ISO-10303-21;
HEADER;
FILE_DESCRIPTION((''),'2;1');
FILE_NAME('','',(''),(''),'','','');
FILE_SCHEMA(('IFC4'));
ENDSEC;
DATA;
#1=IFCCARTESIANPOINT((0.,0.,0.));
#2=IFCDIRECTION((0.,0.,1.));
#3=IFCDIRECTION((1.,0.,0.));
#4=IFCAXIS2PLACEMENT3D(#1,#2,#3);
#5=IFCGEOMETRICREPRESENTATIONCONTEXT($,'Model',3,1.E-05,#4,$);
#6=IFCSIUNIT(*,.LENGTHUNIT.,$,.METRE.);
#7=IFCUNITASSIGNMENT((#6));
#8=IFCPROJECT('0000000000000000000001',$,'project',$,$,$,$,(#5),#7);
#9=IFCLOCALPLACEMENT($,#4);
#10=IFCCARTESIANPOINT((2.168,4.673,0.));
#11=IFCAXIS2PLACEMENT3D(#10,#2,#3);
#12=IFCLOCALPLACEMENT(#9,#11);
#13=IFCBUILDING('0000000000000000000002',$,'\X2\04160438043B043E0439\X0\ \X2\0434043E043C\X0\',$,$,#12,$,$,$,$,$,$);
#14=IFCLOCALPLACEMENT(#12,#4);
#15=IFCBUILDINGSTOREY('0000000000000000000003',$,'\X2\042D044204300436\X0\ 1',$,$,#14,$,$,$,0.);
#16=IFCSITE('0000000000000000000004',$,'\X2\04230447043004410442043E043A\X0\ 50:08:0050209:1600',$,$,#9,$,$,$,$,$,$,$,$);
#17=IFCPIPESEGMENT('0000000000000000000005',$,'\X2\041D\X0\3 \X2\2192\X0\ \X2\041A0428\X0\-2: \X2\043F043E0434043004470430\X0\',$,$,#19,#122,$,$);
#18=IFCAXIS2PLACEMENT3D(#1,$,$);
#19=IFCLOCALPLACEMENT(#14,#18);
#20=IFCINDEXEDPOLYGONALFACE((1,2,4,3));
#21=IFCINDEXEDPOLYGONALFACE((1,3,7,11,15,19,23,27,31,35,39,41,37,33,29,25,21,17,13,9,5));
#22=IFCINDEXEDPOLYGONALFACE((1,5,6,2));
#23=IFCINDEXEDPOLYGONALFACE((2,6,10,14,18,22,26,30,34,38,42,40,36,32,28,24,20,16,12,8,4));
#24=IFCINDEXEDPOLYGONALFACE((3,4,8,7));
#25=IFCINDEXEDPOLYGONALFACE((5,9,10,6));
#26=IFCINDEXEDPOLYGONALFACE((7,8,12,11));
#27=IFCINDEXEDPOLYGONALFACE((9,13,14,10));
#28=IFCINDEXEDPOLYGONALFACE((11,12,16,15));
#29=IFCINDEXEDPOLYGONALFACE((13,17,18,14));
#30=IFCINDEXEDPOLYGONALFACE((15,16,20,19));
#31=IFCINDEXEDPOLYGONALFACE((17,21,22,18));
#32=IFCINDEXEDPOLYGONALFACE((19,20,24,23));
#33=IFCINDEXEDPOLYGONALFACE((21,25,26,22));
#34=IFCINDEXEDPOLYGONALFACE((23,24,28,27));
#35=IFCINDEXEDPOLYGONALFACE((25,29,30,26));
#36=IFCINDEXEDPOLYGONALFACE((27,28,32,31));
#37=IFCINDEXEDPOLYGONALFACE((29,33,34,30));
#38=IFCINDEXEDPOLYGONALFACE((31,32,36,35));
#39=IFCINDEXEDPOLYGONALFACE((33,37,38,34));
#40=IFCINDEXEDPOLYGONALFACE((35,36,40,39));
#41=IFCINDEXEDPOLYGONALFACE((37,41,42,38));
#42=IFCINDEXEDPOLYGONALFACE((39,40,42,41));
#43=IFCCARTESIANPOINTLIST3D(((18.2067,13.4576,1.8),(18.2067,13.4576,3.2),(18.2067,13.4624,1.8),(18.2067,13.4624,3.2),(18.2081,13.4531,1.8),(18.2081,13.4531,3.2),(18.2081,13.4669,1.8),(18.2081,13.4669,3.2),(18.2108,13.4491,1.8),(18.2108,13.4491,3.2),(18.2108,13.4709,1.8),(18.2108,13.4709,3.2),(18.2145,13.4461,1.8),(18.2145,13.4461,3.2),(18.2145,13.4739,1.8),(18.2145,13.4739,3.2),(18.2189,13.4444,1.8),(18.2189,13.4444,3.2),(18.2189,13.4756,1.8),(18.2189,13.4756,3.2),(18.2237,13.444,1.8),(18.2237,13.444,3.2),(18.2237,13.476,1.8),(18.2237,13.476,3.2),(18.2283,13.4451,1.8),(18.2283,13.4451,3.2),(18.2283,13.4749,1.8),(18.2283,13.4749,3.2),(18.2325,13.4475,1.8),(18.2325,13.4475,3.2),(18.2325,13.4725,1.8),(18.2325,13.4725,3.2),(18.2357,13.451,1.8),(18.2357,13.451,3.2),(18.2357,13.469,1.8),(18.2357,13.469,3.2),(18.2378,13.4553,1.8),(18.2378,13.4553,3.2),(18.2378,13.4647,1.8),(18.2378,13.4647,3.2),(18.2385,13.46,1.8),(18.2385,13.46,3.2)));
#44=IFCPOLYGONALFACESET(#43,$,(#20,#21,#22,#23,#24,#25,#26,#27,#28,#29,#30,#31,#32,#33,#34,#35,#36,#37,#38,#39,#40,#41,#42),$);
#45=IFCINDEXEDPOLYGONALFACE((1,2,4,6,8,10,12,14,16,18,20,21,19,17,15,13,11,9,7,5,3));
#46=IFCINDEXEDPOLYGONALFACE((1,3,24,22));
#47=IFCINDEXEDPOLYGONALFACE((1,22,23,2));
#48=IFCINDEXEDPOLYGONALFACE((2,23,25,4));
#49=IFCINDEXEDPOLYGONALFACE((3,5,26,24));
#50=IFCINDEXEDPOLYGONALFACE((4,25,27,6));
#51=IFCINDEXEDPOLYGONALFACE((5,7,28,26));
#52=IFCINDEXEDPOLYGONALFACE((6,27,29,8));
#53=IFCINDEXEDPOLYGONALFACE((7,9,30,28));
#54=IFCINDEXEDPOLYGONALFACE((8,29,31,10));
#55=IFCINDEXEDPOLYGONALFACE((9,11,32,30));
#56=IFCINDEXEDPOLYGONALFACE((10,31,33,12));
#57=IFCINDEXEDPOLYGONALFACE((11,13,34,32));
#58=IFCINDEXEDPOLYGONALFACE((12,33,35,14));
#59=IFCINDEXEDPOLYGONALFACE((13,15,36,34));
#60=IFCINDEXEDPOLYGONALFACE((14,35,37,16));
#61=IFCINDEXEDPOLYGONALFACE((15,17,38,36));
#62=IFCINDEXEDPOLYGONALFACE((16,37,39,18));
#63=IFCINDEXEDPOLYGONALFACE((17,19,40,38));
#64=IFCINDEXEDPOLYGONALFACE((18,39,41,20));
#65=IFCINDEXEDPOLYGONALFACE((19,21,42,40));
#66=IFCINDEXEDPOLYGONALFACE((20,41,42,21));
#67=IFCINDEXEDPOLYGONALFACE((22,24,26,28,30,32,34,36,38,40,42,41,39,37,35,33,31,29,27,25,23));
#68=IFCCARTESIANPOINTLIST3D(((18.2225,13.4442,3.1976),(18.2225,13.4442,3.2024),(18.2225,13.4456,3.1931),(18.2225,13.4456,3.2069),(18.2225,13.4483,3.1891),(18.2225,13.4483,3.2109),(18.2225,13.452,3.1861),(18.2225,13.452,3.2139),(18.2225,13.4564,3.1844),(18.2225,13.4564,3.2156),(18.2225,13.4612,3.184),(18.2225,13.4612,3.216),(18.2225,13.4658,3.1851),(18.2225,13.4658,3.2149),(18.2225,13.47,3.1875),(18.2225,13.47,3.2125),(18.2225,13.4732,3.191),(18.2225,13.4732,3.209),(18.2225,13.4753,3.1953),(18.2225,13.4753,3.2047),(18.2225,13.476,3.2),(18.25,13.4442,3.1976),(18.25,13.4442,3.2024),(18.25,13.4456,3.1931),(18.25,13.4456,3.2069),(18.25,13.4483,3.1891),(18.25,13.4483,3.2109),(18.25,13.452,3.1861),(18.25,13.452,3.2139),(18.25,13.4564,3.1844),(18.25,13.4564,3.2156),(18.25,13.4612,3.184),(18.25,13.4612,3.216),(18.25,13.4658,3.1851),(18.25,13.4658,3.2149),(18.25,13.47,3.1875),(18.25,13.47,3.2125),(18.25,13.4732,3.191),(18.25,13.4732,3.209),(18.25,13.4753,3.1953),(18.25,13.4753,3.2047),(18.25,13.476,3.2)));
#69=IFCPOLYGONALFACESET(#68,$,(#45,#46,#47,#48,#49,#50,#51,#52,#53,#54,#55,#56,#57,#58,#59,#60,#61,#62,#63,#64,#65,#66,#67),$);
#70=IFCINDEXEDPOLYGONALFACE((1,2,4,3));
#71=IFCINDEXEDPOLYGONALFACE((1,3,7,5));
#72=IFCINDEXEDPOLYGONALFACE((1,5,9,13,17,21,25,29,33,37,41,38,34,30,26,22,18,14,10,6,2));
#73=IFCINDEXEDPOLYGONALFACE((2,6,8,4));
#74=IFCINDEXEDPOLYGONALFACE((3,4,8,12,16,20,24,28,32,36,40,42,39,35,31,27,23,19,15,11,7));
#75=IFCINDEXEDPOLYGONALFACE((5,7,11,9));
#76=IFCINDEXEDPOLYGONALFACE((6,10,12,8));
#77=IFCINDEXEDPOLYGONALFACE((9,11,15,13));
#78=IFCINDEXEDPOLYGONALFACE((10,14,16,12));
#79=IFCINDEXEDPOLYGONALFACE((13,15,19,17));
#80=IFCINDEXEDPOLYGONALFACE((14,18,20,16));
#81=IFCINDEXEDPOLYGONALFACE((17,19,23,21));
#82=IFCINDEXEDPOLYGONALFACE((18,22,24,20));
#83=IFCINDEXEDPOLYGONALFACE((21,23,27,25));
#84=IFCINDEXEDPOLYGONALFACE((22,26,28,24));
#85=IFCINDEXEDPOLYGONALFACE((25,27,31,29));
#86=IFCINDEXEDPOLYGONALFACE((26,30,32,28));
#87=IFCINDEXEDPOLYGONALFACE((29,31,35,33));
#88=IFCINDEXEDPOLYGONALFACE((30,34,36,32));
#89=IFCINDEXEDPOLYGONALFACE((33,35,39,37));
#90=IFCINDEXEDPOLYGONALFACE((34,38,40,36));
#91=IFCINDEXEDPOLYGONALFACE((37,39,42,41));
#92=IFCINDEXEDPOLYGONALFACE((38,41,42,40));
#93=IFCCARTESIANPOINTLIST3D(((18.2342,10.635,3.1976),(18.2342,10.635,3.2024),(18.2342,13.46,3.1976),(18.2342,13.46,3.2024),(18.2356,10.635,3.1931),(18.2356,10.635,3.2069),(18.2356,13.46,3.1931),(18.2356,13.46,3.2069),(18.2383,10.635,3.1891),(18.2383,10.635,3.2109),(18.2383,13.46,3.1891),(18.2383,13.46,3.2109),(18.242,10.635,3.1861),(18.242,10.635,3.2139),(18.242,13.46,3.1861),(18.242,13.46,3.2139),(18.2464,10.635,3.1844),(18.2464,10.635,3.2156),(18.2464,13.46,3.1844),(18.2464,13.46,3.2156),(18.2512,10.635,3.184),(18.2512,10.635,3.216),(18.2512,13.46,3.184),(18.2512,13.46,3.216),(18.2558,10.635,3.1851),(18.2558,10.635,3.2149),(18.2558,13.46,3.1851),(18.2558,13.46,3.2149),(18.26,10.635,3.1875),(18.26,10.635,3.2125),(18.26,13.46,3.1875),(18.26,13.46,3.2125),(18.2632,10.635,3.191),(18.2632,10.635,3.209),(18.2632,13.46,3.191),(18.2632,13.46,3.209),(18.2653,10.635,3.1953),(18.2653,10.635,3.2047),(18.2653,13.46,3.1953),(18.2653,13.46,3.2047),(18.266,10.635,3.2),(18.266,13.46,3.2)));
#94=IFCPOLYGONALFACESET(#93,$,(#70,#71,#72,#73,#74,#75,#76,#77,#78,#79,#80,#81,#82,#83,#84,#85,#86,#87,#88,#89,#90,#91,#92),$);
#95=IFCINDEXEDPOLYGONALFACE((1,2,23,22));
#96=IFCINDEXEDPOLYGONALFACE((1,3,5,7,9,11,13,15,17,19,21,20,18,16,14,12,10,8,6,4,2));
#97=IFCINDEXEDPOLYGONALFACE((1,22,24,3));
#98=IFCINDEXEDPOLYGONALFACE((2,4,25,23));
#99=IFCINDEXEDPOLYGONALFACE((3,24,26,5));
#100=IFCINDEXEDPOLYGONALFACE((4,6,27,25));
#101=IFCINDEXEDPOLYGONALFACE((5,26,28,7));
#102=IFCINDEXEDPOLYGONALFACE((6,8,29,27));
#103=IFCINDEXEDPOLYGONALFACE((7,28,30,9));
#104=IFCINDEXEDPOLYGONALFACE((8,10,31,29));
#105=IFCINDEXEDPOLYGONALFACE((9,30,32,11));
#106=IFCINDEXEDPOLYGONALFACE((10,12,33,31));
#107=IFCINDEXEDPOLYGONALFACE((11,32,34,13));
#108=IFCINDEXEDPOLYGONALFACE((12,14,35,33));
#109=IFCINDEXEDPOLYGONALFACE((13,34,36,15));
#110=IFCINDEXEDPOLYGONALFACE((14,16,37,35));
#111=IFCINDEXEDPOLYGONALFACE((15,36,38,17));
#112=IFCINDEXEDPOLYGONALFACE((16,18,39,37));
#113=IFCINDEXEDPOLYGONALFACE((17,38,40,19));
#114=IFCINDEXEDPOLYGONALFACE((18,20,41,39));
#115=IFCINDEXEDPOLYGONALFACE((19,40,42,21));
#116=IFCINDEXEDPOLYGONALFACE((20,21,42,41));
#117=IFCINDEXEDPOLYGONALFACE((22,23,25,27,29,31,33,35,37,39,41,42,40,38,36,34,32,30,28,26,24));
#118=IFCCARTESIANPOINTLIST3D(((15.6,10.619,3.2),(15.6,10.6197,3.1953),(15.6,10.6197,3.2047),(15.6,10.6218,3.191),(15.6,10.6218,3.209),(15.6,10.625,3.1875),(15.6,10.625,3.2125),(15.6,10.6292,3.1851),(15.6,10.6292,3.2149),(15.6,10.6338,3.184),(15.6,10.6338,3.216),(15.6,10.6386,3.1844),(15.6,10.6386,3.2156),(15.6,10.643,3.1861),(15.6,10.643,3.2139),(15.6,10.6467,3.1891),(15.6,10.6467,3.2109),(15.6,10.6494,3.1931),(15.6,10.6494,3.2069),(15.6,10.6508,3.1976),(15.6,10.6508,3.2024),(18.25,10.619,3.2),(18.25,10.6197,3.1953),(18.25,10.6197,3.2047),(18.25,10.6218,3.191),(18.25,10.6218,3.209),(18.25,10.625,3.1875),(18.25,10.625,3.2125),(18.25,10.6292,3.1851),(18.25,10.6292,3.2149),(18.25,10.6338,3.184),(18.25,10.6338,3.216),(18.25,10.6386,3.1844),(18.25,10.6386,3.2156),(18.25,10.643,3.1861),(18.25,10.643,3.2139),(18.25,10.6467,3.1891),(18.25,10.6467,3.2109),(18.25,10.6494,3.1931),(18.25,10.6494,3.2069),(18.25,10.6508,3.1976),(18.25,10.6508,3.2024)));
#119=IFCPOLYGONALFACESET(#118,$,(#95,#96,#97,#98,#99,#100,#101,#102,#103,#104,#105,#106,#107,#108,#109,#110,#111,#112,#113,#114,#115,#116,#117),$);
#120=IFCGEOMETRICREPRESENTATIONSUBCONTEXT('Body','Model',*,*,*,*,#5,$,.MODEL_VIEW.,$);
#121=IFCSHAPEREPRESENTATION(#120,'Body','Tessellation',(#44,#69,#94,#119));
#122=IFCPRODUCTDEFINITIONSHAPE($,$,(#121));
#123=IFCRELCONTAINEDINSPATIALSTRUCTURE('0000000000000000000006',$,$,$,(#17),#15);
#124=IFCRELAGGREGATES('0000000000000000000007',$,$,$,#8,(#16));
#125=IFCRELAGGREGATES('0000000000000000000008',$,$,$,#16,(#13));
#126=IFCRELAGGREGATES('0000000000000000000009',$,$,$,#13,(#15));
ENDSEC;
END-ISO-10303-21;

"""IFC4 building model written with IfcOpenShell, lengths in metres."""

from ifc_helpers import new_model, si_unit, frame, origin_with_axes, origin_2d, place, context, subcontext, project, spatial, circle, extrude, element, save


model = new_model("IFC4")

# Units and contexts
model_context = context("Model", 3, precision=1e-05, world=origin_with_axes())
body_context = subcontext(model_context, "Body", "Model", "MODEL_VIEW")
ifc_project = project(units=[si_unit("LENGTHUNIT", "METRE")], contexts=[model_context])

# Site, building, storey
site_placement = place(None, origin_with_axes())
site = spatial("IfcSite", under=ifc_project, at=site_placement, Name="Участок 50:08:0050209:1600")
building_placement = place(site_placement, frame((2.168, 4.673, 0.0), z_axis=(0.0, 0.0, 1.0), x_axis=(1.0, 0.0, 0.0)))
building = spatial("IfcBuilding", under=site, at=building_placement, Name="Жилой дом")
storey_placement = place(building_placement, origin_with_axes())
storey = spatial("IfcBuildingStorey", under=building, at=storey_placement, Name="Этаж 1", Elevation=0.0)

# Pipe segment
pipe_segment_1_placement = place(storey_placement, origin_with_axes())
element("IfcPipeSegment", 1, at=pipe_segment_1_placement, inside=storey, Name="Н3 → КШ-2: подача", context=body_context, shape_type="SweptSolid", body=[
    extrude(circle(Radius=0.016, at=origin_2d()), frame((18.2225, 13.46, 1.8), z_axis=(0.0, 0.0, 1.0), x_axis=(1.0, 0.0, 0.0)), (0.0, 0.0, 1.0), 1.4),
    extrude(circle(Radius=0.016, at=origin_2d()), frame((18.2225, 13.46, 3.2), z_axis=(1.0, 0.0, 0.0), x_axis=(0.0, 1.0, 0.0)), (0.0, 0.0, 1.0), 0.0275),
    extrude(circle(Radius=0.016, at=origin_2d()), frame((18.25, 13.46, 3.2), z_axis=(0.0, -1.0, 0.0), x_axis=(1.0, 0.0, 0.0)), (0.0, 0.0, 1.0), 2.825),
    extrude(circle(Radius=0.016, at=origin_2d()), frame((18.25, 10.635, 3.2), z_axis=(-1.0, 0.0, 0.0), x_axis=(0.0, -1.0, 0.0)), (0.0, 0.0, 1.0), 2.65),
])

save(model, "model.ifc")
